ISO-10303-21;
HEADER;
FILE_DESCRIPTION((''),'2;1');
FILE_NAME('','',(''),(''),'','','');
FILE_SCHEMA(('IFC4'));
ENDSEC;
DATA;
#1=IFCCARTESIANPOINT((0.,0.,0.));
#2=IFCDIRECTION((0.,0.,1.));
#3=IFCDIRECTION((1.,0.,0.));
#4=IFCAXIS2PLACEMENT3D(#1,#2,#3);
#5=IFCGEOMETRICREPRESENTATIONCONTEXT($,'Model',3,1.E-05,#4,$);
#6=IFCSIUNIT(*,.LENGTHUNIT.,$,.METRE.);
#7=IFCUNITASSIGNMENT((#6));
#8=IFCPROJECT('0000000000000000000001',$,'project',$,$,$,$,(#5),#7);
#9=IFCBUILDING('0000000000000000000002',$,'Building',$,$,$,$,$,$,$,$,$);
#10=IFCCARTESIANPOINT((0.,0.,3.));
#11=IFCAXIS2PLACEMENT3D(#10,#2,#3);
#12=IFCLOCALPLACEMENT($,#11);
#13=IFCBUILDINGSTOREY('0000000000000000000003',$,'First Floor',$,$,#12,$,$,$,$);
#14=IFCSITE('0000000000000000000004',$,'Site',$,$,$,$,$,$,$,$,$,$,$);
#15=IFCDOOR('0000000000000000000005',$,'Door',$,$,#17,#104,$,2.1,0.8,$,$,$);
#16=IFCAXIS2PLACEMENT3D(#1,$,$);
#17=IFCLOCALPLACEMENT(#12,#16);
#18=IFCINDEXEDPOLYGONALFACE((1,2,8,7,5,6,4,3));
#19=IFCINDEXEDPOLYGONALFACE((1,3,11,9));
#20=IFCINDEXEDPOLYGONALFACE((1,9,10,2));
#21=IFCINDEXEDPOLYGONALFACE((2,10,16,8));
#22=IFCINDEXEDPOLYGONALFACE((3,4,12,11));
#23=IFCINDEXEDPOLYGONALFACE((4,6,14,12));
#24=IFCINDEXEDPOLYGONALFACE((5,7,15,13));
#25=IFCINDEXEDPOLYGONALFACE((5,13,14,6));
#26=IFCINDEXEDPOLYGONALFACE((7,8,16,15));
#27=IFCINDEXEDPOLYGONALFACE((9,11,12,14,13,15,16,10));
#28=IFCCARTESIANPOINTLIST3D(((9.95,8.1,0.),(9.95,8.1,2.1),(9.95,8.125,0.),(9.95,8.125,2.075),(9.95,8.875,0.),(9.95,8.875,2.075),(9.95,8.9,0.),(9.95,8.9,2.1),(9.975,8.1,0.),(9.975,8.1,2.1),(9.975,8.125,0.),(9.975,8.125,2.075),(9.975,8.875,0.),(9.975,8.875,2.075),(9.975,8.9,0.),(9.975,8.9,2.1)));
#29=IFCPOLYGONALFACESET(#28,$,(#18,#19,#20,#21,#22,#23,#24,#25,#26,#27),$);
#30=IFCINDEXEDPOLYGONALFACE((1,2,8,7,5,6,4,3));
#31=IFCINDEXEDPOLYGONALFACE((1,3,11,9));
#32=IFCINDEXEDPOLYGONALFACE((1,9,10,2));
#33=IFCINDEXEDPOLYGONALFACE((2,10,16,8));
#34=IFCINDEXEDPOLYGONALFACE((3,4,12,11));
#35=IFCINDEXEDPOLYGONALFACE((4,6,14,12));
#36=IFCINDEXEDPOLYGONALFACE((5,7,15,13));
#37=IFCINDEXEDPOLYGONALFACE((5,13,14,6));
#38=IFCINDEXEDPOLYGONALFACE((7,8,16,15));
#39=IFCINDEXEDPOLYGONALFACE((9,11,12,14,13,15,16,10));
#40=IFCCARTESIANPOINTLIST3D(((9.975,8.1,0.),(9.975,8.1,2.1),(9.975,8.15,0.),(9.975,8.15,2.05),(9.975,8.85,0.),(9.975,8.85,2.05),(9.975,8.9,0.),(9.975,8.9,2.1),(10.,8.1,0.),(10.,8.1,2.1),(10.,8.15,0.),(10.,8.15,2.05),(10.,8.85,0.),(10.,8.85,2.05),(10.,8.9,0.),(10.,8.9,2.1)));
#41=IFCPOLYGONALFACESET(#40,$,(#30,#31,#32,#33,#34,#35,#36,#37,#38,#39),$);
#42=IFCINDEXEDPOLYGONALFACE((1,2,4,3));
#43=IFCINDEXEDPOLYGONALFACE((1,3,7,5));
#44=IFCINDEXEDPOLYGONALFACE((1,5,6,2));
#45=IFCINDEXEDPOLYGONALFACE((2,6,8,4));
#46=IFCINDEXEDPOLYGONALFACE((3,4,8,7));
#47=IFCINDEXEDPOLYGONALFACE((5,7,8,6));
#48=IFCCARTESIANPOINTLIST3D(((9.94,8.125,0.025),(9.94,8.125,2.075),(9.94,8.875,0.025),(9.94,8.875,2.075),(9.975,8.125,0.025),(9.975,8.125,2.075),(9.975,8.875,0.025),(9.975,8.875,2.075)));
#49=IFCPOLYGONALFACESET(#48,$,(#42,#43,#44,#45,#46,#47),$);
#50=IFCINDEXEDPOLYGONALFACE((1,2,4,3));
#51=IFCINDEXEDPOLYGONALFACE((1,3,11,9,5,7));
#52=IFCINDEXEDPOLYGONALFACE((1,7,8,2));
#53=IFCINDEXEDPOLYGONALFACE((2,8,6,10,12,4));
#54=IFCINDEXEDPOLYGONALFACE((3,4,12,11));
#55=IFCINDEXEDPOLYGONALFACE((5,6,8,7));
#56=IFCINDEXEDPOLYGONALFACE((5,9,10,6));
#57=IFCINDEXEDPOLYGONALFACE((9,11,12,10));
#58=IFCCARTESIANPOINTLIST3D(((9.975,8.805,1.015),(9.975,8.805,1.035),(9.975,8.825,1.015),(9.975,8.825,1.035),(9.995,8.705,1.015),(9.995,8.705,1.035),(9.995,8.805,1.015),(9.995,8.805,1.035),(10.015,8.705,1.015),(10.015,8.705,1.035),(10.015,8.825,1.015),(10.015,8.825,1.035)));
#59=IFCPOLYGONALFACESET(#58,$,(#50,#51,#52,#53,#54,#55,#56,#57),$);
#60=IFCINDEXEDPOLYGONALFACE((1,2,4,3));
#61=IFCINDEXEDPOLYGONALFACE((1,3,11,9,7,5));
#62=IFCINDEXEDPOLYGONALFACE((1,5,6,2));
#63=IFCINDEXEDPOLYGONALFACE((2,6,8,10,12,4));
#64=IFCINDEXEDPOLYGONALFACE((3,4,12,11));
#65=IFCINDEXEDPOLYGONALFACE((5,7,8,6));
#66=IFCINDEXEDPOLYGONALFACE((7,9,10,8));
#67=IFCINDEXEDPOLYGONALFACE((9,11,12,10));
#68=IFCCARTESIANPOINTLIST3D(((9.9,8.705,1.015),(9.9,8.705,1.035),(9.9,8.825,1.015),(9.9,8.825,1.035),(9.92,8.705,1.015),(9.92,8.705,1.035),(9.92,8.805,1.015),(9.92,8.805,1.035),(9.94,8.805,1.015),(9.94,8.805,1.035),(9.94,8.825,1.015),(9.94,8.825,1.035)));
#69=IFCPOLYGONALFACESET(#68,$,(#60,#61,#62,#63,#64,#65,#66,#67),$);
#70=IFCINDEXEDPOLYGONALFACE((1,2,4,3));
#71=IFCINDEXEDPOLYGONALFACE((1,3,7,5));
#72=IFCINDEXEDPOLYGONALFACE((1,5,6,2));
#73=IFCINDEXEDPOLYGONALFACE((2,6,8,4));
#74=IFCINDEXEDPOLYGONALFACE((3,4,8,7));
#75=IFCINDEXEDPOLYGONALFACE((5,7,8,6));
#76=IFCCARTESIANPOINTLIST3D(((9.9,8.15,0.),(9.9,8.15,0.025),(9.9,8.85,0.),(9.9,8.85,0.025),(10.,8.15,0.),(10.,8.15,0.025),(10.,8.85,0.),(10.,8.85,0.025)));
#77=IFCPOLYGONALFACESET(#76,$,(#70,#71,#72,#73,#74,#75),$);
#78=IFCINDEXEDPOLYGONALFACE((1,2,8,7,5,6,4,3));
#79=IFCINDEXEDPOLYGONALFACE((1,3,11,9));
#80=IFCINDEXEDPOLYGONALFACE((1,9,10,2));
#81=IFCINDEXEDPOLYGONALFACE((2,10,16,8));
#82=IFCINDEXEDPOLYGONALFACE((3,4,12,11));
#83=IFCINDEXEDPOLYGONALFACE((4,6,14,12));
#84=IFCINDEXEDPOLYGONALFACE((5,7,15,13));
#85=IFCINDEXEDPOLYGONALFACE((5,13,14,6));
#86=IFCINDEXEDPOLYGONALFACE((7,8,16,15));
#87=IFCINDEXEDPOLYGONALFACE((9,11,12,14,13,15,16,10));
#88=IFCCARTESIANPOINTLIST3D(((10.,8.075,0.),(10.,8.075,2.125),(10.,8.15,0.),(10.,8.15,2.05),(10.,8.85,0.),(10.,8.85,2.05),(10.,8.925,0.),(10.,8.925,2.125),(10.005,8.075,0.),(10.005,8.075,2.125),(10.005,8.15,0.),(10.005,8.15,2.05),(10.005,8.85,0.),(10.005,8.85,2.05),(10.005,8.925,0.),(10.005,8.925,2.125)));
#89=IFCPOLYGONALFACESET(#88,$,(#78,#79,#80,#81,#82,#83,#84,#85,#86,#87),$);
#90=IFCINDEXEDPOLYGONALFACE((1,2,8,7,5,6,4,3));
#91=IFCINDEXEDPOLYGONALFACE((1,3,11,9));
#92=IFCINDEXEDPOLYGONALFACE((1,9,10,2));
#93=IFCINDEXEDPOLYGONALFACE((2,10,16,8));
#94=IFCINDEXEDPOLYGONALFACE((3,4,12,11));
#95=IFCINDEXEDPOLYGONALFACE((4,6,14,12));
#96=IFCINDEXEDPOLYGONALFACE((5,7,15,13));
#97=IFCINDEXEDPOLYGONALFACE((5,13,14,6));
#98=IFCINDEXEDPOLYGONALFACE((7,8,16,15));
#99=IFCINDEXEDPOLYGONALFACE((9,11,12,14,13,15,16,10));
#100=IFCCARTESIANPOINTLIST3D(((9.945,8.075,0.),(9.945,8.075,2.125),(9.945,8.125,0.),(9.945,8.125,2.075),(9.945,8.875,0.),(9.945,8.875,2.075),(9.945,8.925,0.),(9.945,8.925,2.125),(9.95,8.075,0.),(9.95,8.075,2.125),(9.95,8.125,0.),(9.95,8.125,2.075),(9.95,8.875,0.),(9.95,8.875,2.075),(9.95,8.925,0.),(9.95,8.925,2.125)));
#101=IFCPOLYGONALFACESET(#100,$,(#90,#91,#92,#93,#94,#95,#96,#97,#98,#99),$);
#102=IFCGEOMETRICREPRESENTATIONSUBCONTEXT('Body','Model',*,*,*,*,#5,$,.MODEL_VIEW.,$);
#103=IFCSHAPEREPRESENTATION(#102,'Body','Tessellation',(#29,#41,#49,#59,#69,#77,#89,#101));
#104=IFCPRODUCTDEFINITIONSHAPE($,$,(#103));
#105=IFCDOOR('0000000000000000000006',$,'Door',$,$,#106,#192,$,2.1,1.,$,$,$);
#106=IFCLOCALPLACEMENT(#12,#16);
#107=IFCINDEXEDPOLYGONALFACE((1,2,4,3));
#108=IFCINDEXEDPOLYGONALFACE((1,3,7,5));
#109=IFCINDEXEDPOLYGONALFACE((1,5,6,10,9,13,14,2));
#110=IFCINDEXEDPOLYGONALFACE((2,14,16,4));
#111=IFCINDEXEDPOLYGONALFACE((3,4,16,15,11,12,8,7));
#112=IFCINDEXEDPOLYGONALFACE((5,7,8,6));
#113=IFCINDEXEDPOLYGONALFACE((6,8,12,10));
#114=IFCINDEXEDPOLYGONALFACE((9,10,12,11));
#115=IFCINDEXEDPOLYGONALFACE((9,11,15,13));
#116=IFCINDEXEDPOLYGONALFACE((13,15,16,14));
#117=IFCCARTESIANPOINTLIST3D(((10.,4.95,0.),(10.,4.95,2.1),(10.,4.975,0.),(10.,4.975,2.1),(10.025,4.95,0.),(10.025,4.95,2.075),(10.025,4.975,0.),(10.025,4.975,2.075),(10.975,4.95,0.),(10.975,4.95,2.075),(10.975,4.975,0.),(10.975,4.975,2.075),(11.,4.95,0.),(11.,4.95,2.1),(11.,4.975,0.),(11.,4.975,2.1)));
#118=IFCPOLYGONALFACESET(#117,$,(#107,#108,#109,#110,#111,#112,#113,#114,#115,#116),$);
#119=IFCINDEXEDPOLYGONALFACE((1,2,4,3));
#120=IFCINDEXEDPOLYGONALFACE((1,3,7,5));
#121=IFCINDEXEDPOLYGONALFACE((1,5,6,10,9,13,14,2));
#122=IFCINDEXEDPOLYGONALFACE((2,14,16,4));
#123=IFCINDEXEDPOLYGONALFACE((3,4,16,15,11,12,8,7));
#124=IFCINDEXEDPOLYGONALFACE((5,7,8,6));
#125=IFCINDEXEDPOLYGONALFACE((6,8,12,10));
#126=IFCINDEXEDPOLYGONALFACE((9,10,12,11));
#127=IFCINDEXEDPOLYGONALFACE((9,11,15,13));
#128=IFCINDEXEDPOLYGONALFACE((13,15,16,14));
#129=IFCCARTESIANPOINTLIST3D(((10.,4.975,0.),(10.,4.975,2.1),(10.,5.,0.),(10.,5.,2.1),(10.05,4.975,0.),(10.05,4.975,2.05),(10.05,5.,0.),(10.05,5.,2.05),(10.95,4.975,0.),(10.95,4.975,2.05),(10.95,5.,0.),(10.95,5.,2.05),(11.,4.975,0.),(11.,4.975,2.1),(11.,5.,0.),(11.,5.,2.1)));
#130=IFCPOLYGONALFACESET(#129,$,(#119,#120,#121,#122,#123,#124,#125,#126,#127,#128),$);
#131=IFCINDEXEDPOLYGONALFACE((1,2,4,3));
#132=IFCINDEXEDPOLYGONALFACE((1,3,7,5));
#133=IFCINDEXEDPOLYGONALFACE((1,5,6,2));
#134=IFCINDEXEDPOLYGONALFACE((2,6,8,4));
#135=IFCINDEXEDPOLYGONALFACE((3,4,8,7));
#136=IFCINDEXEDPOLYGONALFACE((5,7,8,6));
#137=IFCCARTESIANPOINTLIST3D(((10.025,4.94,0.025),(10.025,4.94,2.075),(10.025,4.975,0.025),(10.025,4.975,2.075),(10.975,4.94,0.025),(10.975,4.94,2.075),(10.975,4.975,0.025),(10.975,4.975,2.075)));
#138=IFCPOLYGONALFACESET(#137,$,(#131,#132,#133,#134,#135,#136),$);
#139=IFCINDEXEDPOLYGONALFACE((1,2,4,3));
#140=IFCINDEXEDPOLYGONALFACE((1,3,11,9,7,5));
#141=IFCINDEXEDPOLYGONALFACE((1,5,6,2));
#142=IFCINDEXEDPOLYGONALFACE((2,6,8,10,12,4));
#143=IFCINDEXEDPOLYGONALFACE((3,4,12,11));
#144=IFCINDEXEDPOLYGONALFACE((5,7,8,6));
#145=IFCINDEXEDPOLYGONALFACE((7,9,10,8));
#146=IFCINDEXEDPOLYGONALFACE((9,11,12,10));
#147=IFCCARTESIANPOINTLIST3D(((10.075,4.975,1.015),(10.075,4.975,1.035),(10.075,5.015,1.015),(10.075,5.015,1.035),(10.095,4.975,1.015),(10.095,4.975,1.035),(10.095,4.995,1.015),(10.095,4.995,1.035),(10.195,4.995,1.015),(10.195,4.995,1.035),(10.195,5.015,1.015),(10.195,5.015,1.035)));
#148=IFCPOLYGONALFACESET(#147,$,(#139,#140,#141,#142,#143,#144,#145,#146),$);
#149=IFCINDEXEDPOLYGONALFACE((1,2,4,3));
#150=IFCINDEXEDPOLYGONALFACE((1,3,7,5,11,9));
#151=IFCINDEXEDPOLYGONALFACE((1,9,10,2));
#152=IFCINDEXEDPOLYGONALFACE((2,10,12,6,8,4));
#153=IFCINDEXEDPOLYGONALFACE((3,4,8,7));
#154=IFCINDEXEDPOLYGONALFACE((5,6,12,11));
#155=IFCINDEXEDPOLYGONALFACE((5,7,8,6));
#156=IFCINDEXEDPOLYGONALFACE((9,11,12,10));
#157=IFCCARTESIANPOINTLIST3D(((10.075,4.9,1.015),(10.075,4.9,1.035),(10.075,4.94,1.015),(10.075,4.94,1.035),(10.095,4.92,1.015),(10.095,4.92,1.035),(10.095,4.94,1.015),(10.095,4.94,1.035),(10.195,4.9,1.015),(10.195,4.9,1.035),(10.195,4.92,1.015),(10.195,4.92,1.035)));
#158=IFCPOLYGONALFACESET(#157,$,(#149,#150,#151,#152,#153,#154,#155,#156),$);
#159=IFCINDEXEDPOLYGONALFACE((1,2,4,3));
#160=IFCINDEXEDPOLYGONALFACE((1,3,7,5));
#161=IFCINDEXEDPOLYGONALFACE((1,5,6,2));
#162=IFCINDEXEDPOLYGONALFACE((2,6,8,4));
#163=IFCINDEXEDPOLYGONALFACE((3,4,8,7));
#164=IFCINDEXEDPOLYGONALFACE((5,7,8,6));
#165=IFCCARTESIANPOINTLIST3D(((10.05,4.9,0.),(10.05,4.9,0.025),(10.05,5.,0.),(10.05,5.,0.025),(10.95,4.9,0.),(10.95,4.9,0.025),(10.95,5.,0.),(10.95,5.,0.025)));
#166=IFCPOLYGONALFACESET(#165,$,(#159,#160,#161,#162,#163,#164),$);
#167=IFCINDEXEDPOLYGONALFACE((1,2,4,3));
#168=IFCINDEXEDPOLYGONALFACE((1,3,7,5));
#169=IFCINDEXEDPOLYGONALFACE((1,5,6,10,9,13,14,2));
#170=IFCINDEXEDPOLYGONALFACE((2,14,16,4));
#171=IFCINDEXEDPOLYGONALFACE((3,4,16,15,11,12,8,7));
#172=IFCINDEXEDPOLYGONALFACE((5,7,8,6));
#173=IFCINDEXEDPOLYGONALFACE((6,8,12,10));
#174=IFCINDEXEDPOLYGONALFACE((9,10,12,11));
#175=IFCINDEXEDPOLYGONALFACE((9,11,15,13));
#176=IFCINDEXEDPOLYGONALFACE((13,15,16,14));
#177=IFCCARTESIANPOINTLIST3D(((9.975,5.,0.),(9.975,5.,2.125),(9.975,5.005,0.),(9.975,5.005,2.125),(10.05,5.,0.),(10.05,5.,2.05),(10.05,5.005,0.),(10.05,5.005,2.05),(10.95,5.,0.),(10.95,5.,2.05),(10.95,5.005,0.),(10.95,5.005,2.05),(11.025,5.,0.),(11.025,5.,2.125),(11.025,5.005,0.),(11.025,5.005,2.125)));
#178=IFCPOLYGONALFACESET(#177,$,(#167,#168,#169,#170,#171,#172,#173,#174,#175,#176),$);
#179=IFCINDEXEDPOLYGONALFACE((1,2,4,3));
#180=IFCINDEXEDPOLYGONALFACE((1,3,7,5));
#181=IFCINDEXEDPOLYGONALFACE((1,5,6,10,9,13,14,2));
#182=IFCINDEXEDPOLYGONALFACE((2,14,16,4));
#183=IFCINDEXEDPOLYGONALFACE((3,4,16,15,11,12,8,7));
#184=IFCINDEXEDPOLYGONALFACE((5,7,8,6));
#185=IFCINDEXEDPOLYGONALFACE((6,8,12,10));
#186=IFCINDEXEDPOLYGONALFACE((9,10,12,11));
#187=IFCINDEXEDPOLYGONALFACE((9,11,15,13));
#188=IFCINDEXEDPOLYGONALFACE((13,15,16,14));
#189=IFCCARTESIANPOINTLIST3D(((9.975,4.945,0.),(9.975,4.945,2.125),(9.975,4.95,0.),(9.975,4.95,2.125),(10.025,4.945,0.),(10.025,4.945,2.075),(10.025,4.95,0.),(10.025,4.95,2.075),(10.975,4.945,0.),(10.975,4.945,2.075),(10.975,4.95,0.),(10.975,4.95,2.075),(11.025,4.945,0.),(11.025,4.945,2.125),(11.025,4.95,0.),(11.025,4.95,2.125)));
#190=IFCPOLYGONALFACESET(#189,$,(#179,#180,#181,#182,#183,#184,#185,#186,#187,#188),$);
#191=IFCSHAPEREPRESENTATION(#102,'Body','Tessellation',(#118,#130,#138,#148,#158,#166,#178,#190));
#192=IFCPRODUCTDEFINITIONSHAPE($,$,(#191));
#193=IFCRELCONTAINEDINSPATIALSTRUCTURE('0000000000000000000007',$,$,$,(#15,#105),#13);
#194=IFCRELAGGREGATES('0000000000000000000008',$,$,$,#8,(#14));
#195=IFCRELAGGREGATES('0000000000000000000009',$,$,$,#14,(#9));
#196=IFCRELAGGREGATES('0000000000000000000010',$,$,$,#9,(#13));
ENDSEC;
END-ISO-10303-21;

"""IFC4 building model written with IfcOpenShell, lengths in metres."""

from ifc_helpers import new_model, si_unit, frame, origin_with_axes, place, context, subcontext, project, spatial, line, indexed_curve, outline, extrude, element, save


model = new_model("IFC4")

# Units and contexts
model_context = context("Model", 3, precision=1e-05, world=origin_with_axes())
body_context = subcontext(model_context, "Body", "Model", "MODEL_VIEW")
ifc_project = project(units=[si_unit("LENGTHUNIT", "METRE")], contexts=[model_context])

# Site, building, storey
site = spatial("IfcSite", under=ifc_project, Name="Site")
building = spatial("IfcBuilding", under=site, Name="Building")
storey_placement = place(None, frame((0.0, 0.0, 3.0), z_axis=(0.0, 0.0, 1.0), x_axis=(1.0, 0.0, 0.0)))
storey = spatial("IfcBuildingStorey", under=building, at=storey_placement, Name="First Floor")

# Doors
door_1_placement = place(storey_placement, frame((10.0, 8.1, 0.0), z_axis=(0.0, 0.0, 1.0), x_axis=(0.0, 1.0, 0.0)))
element("IfcDoor", 1, at=door_1_placement, inside=storey, Name="Door", OverallHeight=2.1, OverallWidth=0.8, context=body_context, shape_type="SweptSolid", body=[
    extrude(outline(indexed_curve([(0.0, 0.0), (0.0, 2.1), (0.8, 2.1), (0.8, 0.0), (0.775, 0.0), (0.775, 2.075), (0.025, 2.075), (0.025, 0.0)], segments=[line(1, 2, 3, 4, 5, 6, 7, 8, 1)])), frame((0.0, 0.025, 0.0), z_axis=(0.0, -1.0, 0.0), x_axis=(1.0, 0.0, 0.0)), (0.0, 0.0, -1.0), 0.025),
    extrude(outline(indexed_curve([(0.0, 0.0), (0.0, 2.1), (0.8, 2.1), (0.8, 0.0), (0.75, 0.0), (0.75, 2.05), (0.05, 2.05), (0.05, 0.0)], segments=[line(1, 2, 3, 4, 5, 6, 7, 8, 1)])), frame((0.0, 0.0, 0.0), z_axis=(0.0, -1.0, 0.0), x_axis=(1.0, 0.0, 0.0)), (0.0, 0.0, -1.0), 0.025),
    extrude(outline(indexed_curve([(0.0, 0.0), (0.75, 0.0), (0.75, 0.035), (0.0, 0.035)], segments=[line(1, 2, 3, 4, 1)])), frame((0.025, 0.025, 0.025), z_axis=(0.0, 0.0, 1.0), x_axis=(1.0, 0.0, 0.0)), (0.0, 0.0, 1.0), 2.05),
    extrude(outline(indexed_curve([(0.0, 0.0), (0.0, -0.04), (-0.12, -0.04), (-0.12, -0.02), (-0.02, -0.02), (-0.02, 0.0)], segments=[line(1, 2, 3, 4, 5, 6, 1)])), frame((0.725, 0.025, 1.015), z_axis=(0.0, 0.0, 1.0), x_axis=(1.0, 0.0, 0.0)), (0.0, 0.0, 1.0), 0.02),
    extrude(outline(indexed_curve([(0.0, 0.0), (0.0, 0.04), (-0.12, 0.04), (-0.12, 0.02), (-0.02, 0.02), (-0.02, 0.0)], segments=[line(1, 2, 3, 4, 5, 6, 1)])), frame((0.725, 0.06, 1.015), z_axis=(0.0, 0.0, 1.0), x_axis=(1.0, 0.0, 0.0)), (0.0, 0.0, 1.0), 0.02),
    extrude(outline(indexed_curve([(0.0, 0.0), (0.7, 0.0), (0.7, 0.1), (0.0, 0.1)], segments=[line(1, 2, 3, 4, 1)])), frame((0.05, 0.0, 0.0), z_axis=(0.0, 0.0, 1.0), x_axis=(1.0, 0.0, 0.0)), (0.0, 0.0, 1.0), 0.025),
    extrude(outline(indexed_curve([(0.0, 0.0), (0.0, 2.125), (0.85, 2.125), (0.85, 0.0), (0.775, 0.0), (0.775, 2.05), (0.075, 2.05), (0.075, 0.0)], segments=[line(1, 2, 3, 4, 5, 6, 7, 8, 1)])), frame((-0.025, -0.005, 0.0), z_axis=(0.0, -1.0, 0.0), x_axis=(1.0, 0.0, 0.0)), (0.0, 0.0, -1.0), 0.005),
    extrude(outline(indexed_curve([(0.0, 0.0), (0.0, 2.125), (0.85, 2.125), (0.85, 0.0), (0.8, 0.0), (0.8, 2.075), (0.05, 2.075), (0.05, 0.0)], segments=[line(1, 2, 3, 4, 5, 6, 7, 8, 1)])), frame((-0.025, 0.05, 0.0), z_axis=(0.0, -1.0, 0.0), x_axis=(1.0, 0.0, 0.0)), (0.0, 0.0, -1.0), 0.005),
])
door_2_placement = place(storey_placement, frame((11.0, 5.0, 0.0), z_axis=(0.0, 0.0, 1.0), x_axis=(-1.0, 0.0, 0.0)))
element("IfcDoor", 2, at=door_2_placement, inside=storey, Name="Door", OverallHeight=2.1, OverallWidth=1.0, context=body_context, shape_type="SweptSolid", body=[
    extrude(outline(indexed_curve([(0.0, 0.0), (0.0, 2.1), (1.0, 2.1), (1.0, 0.0), (0.975, 0.0), (0.975, 2.075), (0.025, 2.075), (0.025, 0.0)], segments=[line(1, 2, 3, 4, 5, 6, 7, 8, 1)])), frame((0.0, 0.025, 0.0), z_axis=(0.0, -1.0, 0.0), x_axis=(1.0, 0.0, 0.0)), (0.0, 0.0, -1.0), 0.025),
    extrude(outline(indexed_curve([(0.0, 0.0), (0.0, 2.1), (1.0, 2.1), (1.0, 0.0), (0.95, 0.0), (0.95, 2.05), (0.05, 2.05), (0.05, 0.0)], segments=[line(1, 2, 3, 4, 5, 6, 7, 8, 1)])), frame((0.0, 0.0, 0.0), z_axis=(0.0, -1.0, 0.0), x_axis=(1.0, 0.0, 0.0)), (0.0, 0.0, -1.0), 0.025),
    extrude(outline(indexed_curve([(0.0, 0.0), (0.95, 0.0), (0.95, 0.035), (0.0, 0.035)], segments=[line(1, 2, 3, 4, 1)])), frame((0.025, 0.025, 0.025), z_axis=(0.0, 0.0, 1.0), x_axis=(1.0, 0.0, 0.0)), (0.0, 0.0, 1.0), 2.05),
    extrude(outline(indexed_curve([(0.0, 0.0), (0.0, -0.04), (-0.12, -0.04), (-0.12, -0.02), (-0.02, -0.02), (-0.02, 0.0)], segments=[line(1, 2, 3, 4, 5, 6, 1)])), frame((0.925, 0.025, 1.015), z_axis=(0.0, 0.0, 1.0), x_axis=(1.0, 0.0, 0.0)), (0.0, 0.0, 1.0), 0.02),
    extrude(outline(indexed_curve([(0.0, 0.0), (0.0, 0.04), (-0.12, 0.04), (-0.12, 0.02), (-0.02, 0.02), (-0.02, 0.0)], segments=[line(1, 2, 3, 4, 5, 6, 1)])), frame((0.925, 0.06, 1.015), z_axis=(0.0, 0.0, 1.0), x_axis=(1.0, 0.0, 0.0)), (0.0, 0.0, 1.0), 0.02),
    extrude(outline(indexed_curve([(0.0, 0.0), (0.9, 0.0), (0.9, 0.1), (0.0, 0.1)], segments=[line(1, 2, 3, 4, 1)])), frame((0.05, 0.0, 0.0), z_axis=(0.0, 0.0, 1.0), x_axis=(1.0, 0.0, 0.0)), (0.0, 0.0, 1.0), 0.025),
    extrude(outline(indexed_curve([(0.0, 0.0), (0.0, 2.125), (1.05, 2.125), (1.05, 0.0), (0.975, 0.0), (0.975, 2.05), (0.075, 2.05), (0.075, 0.0)], segments=[line(1, 2, 3, 4, 5, 6, 7, 8, 1)])), frame((-0.025, -0.005, 0.0), z_axis=(0.0, -1.0, 0.0), x_axis=(1.0, 0.0, 0.0)), (0.0, 0.0, -1.0), 0.005),
    extrude(outline(indexed_curve([(0.0, 0.0), (0.0, 2.125), (1.05, 2.125), (1.05, 0.0), (1.0, 0.0), (1.0, 2.075), (0.05, 2.075), (0.05, 0.0)], segments=[line(1, 2, 3, 4, 5, 6, 7, 8, 1)])), frame((-0.025, 0.05, 0.0), z_axis=(0.0, -1.0, 0.0), x_axis=(1.0, 0.0, 0.0)), (0.0, 0.0, -1.0), 0.005),
])

save(model, "model.ifc")
